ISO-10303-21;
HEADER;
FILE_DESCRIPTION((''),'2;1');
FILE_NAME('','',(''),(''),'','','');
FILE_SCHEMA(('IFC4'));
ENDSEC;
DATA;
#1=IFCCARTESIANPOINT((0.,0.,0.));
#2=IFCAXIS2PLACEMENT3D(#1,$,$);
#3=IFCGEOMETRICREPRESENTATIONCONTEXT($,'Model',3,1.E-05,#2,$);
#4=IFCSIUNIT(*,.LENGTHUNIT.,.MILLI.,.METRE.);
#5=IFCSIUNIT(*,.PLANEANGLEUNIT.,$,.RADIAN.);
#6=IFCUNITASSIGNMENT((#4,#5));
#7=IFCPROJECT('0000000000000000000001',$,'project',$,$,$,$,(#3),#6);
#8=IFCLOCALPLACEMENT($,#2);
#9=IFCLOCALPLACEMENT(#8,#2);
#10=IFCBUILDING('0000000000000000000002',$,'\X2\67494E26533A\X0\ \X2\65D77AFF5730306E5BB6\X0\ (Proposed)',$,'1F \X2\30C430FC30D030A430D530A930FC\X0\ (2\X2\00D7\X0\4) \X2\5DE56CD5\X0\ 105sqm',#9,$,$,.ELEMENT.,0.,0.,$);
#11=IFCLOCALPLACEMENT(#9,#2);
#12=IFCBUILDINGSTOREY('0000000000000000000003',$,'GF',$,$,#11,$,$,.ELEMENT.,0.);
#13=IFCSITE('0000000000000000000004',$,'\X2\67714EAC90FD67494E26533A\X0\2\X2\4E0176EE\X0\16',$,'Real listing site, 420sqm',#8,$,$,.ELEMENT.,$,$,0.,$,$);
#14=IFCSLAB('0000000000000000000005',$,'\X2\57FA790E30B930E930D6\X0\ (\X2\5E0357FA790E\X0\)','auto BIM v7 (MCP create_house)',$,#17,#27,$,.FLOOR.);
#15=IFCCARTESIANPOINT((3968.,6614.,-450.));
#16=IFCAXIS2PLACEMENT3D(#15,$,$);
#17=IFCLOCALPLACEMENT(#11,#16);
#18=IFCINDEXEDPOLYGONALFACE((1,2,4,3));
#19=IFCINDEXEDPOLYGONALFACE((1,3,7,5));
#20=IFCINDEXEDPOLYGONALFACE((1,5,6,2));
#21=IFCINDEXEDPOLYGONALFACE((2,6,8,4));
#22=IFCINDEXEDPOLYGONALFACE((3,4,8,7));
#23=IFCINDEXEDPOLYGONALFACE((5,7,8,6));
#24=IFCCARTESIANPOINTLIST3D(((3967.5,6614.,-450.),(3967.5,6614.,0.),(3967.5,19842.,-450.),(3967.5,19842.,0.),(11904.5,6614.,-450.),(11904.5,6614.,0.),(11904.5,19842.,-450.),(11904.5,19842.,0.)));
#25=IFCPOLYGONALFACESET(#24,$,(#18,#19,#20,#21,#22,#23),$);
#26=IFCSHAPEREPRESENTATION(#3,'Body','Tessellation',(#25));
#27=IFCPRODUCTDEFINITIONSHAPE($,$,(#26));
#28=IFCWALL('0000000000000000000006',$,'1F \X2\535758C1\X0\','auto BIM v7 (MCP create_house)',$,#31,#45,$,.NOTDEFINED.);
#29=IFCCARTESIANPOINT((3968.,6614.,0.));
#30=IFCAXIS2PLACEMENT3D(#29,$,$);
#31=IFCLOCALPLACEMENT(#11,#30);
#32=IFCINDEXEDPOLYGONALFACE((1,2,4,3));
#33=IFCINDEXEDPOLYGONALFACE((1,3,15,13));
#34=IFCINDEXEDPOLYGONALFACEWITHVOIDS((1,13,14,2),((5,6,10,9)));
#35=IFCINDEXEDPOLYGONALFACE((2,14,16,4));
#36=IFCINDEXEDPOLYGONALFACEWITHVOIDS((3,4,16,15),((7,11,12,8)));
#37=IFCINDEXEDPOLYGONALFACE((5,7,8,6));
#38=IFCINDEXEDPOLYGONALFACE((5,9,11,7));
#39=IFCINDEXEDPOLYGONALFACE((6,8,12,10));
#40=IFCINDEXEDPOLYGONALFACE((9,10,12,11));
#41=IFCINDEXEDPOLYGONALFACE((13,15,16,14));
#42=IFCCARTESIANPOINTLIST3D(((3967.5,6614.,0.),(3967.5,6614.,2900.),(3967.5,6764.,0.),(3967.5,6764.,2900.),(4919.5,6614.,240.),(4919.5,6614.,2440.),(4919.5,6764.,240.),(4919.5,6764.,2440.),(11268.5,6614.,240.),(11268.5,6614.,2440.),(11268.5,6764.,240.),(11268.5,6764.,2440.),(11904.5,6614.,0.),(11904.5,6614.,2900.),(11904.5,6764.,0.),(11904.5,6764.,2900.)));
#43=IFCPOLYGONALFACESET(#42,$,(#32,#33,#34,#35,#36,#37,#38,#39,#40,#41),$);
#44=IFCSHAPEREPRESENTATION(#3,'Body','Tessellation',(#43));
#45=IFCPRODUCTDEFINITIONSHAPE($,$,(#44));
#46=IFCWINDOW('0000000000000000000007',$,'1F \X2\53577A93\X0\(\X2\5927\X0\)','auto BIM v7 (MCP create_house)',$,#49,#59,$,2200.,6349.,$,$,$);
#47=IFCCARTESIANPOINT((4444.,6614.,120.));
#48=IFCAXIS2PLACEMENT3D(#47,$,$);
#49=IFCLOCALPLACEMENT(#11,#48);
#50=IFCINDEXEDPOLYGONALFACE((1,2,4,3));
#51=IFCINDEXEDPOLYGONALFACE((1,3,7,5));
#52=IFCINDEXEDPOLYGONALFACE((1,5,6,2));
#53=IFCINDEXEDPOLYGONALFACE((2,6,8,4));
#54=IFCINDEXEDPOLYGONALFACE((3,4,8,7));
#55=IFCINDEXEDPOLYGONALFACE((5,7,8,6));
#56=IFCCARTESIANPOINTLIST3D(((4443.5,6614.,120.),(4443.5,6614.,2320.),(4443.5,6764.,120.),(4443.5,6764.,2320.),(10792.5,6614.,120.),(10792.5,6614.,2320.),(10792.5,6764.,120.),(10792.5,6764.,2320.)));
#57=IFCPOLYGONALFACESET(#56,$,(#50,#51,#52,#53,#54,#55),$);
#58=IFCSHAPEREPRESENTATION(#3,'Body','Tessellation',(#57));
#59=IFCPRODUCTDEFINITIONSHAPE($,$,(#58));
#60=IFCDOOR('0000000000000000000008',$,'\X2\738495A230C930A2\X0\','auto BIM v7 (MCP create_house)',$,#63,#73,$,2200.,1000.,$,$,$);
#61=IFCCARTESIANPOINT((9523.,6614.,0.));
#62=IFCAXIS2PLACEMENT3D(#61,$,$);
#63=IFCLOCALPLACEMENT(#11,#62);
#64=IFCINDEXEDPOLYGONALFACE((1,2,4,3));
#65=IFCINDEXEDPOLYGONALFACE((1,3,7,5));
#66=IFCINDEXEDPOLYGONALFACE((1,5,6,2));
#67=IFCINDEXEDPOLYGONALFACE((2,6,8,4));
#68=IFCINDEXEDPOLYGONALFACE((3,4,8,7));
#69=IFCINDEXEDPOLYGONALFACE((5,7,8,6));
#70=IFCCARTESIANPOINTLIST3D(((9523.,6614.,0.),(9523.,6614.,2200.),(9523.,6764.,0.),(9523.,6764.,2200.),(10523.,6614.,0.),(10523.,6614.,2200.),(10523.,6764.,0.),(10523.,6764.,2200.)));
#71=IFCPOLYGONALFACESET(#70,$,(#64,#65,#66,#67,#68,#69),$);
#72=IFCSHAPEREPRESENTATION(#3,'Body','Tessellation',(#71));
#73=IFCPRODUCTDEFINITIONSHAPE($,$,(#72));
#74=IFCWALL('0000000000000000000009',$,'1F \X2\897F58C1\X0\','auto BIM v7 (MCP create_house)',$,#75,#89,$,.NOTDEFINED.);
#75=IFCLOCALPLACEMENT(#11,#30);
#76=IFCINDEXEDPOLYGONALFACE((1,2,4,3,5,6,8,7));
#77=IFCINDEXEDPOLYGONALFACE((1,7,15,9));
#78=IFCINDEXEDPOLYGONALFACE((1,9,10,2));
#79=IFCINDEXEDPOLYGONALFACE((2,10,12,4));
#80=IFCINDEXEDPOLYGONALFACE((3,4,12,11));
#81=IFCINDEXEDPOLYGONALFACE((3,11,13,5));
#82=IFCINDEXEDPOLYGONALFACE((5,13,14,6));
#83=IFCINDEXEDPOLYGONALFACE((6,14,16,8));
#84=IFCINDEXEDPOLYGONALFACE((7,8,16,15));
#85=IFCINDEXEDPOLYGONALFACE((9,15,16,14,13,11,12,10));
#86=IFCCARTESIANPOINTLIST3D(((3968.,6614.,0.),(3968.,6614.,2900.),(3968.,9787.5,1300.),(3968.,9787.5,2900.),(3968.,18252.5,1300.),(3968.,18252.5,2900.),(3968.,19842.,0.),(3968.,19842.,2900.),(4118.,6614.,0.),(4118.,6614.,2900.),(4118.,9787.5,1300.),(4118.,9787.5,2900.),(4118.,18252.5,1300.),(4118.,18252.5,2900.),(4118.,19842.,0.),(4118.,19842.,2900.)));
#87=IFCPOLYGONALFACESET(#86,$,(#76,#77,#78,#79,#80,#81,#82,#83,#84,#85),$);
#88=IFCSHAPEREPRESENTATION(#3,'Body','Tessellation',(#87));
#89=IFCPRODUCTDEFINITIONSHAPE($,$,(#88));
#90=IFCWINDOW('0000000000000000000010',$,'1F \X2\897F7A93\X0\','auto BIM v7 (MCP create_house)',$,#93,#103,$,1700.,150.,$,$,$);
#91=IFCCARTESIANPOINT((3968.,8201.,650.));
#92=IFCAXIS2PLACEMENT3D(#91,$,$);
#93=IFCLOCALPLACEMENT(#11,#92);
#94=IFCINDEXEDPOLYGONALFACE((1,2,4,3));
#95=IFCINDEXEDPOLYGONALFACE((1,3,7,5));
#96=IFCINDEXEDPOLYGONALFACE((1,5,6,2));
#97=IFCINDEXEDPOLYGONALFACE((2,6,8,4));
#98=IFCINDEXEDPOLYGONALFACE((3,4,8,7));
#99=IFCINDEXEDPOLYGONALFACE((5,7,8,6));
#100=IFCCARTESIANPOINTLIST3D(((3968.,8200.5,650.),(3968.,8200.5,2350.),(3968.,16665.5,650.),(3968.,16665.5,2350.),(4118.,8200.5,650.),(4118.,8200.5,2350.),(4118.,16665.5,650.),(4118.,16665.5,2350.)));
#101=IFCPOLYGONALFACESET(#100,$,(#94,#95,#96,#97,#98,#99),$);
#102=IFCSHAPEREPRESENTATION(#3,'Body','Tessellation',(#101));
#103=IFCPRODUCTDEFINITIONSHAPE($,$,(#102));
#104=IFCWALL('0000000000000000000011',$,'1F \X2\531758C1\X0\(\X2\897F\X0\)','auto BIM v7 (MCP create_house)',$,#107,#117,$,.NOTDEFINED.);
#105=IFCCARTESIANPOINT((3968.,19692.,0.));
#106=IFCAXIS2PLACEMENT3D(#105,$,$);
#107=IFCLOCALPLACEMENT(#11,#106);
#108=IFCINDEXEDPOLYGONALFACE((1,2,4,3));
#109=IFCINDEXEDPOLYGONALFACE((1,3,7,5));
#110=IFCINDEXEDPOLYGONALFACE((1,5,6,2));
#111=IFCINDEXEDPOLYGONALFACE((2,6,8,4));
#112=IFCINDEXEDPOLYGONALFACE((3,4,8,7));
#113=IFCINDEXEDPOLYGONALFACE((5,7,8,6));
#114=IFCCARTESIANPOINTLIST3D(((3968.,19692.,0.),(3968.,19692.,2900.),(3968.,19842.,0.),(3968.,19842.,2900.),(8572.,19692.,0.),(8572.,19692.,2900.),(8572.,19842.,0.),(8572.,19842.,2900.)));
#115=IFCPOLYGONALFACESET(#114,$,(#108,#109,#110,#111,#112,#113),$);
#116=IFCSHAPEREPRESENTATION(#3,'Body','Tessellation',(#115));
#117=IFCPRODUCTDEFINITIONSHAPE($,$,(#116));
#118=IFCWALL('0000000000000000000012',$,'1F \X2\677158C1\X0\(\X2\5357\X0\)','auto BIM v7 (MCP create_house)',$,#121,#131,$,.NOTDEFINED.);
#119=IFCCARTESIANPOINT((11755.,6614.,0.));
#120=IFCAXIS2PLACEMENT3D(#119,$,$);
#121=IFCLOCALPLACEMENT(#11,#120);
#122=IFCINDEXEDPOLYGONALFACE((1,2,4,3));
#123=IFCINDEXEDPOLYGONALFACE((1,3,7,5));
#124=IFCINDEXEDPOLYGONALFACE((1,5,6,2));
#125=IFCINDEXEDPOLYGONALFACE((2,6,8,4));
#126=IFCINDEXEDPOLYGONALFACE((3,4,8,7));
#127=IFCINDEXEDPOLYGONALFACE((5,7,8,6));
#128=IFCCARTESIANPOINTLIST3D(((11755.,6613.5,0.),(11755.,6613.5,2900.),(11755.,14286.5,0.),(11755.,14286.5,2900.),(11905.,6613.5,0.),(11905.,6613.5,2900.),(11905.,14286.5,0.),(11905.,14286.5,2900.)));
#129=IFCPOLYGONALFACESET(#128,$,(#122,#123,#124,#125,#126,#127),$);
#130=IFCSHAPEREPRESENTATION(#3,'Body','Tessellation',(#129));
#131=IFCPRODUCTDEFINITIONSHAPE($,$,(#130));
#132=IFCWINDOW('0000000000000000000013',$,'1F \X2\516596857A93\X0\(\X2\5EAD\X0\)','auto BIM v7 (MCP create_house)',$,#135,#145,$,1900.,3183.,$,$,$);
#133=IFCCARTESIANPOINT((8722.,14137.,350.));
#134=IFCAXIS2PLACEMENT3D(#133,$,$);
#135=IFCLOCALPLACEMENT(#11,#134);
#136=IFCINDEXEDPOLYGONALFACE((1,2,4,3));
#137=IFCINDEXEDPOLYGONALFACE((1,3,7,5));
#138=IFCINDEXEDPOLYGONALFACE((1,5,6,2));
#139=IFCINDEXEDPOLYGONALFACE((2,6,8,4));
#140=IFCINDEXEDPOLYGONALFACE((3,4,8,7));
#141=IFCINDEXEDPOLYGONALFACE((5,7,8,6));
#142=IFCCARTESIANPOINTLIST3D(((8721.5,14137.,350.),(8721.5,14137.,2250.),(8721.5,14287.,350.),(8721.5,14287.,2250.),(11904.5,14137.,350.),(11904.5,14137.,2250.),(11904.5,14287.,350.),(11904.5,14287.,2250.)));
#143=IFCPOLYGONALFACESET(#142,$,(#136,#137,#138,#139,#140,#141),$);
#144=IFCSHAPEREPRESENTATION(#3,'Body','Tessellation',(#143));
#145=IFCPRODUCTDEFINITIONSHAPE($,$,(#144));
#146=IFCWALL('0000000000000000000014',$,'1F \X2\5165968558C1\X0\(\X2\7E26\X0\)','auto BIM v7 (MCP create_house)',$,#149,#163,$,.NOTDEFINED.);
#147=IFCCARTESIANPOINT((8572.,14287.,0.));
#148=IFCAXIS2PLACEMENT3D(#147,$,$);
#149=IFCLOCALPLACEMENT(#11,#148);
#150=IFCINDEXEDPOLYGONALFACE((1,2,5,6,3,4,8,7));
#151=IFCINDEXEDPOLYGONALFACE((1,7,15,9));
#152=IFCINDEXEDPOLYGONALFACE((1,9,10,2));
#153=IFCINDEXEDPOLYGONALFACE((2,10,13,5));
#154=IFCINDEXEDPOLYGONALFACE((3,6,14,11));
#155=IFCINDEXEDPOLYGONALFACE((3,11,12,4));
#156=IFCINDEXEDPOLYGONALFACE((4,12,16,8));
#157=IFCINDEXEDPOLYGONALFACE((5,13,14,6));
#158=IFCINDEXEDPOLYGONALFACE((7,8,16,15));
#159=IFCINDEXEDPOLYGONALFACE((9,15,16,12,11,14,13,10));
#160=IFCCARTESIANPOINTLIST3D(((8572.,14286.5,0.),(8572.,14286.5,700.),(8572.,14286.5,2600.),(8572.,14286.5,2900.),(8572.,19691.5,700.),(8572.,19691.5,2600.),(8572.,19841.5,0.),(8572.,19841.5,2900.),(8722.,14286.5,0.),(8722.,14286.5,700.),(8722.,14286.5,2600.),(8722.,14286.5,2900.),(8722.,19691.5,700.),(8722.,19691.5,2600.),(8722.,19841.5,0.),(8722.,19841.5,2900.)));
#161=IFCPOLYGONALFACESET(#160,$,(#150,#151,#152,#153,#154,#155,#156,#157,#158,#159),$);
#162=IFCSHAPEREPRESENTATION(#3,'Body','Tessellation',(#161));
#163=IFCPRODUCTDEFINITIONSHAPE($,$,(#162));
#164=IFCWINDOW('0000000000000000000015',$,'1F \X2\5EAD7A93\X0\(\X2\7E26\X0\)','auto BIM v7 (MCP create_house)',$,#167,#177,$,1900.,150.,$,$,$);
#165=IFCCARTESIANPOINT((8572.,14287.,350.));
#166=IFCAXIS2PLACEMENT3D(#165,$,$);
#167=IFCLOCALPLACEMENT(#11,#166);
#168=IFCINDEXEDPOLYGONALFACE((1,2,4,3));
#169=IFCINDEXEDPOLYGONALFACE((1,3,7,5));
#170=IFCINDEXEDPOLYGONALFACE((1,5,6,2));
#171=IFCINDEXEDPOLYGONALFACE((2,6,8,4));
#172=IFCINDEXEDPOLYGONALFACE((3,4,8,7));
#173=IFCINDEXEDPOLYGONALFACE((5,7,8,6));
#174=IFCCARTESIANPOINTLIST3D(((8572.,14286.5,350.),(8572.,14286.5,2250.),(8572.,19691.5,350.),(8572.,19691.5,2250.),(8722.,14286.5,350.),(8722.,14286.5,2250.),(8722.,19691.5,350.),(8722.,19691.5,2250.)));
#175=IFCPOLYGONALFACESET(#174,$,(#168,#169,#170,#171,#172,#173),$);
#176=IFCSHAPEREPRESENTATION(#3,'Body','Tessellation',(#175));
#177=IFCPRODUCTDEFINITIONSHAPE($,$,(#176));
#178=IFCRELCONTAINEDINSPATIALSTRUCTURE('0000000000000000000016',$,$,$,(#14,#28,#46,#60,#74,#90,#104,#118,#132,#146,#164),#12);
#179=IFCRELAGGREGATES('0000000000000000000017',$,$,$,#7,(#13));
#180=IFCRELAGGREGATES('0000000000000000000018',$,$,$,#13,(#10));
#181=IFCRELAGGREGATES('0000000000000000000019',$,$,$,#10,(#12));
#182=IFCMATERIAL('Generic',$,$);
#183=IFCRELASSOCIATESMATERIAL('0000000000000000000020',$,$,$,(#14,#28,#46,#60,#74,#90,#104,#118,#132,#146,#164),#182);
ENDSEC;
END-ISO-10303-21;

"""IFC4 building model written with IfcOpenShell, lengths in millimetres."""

from ifc_helpers import new_model, si_unit, frame, frame_2d, origin, place, context, project, spatial, rectangle, extrude, material, element, fill, save


model = new_model("IFC4")

# Units and contexts
model_context = context("Model", 3, precision=1e-05, world=origin())
ifc_project = project(units=[si_unit("LENGTHUNIT", "METRE", prefix="MILLI"), si_unit("PLANEANGLEUNIT", "RADIAN")], contexts=[model_context])

# Site, building, storey
site_placement = place(None, origin())
site = spatial("IfcSite", under=ifc_project, at=site_placement, Name="東京都杉並区2丁目16", ObjectType="Real listing site, 420sqm", CompositionType="ELEMENT", RefElevation=0.0)
building_placement = place(site_placement, origin())
building = spatial("IfcBuilding", under=site, at=building_placement, Name="杉並区 旗竿地の家 (Proposed)", ObjectType="1F ツーバイフォー (2×4) 工法 105sqm", CompositionType="ELEMENT", ElevationOfRefHeight=0.0, ElevationOfTerrain=0.0)
storey_placement = place(building_placement, origin())
storey = spatial("IfcBuildingStorey", under=building, at=storey_placement, Name="GF", CompositionType="ELEMENT", Elevation=0.0)

# Slab
ifc_material = material(Name="Generic")
slab_1_placement = place(storey_placement, frame((3968.0, 6614.0, -450.0)))
element("IfcSlab", 1, at=slab_1_placement, inside=storey, material=ifc_material, Name="基礎スラブ (布基礎)", Description="auto BIM v7 (MCP create_house)", PredefinedType="FLOOR", context=model_context, shape_type="SweptSolid", body=[
    extrude(rectangle(XDim=7937.0, YDim=13228.0, at=frame_2d((3968.0, 6614.0))), frame((3968.0, 6614.0, -450.0)), (0.0, 0.0, 1.0), 450.0),
])

# Wall, openings, window, door
wall_1_placement = place(storey_placement, frame((3968.0, 6614.0, 0.0)))
wall_1 = element("IfcWall", 2, at=wall_1_placement, inside=storey, material=ifc_material, Name="1F 南壁", Description="auto BIM v7 (MCP create_house)", PredefinedType="NOTDEFINED", context=model_context, shape_type="SweptSolid", body=[
    extrude(rectangle(XDim=7937.0, YDim=150.0, at=frame_2d((3968.0, 75.0))), frame((3968.0, 6614.0, 0.0)), (0.0, 0.0, 1.0), 2900.0),
])
opening_1_placement = place(storey_placement, frame((4444.0, 6614.0, 120.0)))
opening_1 = element("IfcOpeningElement", 3, at=opening_1_placement, cuts=wall_1, PredefinedType="NOTDEFINED", context=model_context, shape_type="SweptSolid", body=[
    extrude(rectangle(XDim=6349.0, YDim=150.0, at=frame_2d((3174.0, 75.0))), frame((4444.0, 6614.0, 120.0)), (0.0, 0.0, 1.0), 2200.0),
])
opening_2_placement = place(storey_placement, frame((9523.0, 6614.0, 0.0)))
opening_2 = element("IfcOpeningElement", 4, at=opening_2_placement, cuts=wall_1, PredefinedType="NOTDEFINED", context=model_context, shape_type="SweptSolid", body=[
    extrude(rectangle(XDim=1000.0, YDim=150.0, at=frame_2d((500.0, 75.0))), frame((9523.0, 6614.0, 0.0)), (0.0, 0.0, 1.0), 2200.0),
])
window_1_placement = place(storey_placement, frame((4444.0, 6614.0, 120.0)))
window_1 = element("IfcWindow", 5, at=window_1_placement, inside=storey, material=ifc_material, Name="1F 南窓(大)", Description="auto BIM v7 (MCP create_house)", OverallHeight=2200.0, OverallWidth=6349.0, context=model_context, shape_type="SweptSolid", body=[
    extrude(rectangle(XDim=6349.0, YDim=150.0, at=frame_2d((3174.0, 75.0))), frame((4444.0, 6614.0, 120.0)), (0.0, 0.0, 1.0), 2200.0),
])
fill(opening_1, window_1)
door_placement = place(storey_placement, frame((9523.0, 6614.0, 0.0)))
door = element("IfcDoor", 6, at=door_placement, inside=storey, material=ifc_material, Name="玄関ドア", Description="auto BIM v7 (MCP create_house)", OverallHeight=2200.0, OverallWidth=1000.0, context=model_context, shape_type="SweptSolid", body=[
    extrude(rectangle(XDim=1000.0, YDim=150.0, at=frame_2d((500.0, 75.0))), frame((9523.0, 6614.0, 0.0)), (0.0, 0.0, 1.0), 2200.0),
])
fill(opening_2, door)

# Wall, opening, window
wall_2_placement = place(storey_placement, frame((3968.0, 6614.0, 0.0)))
wall_2 = element("IfcWall", 7, at=wall_2_placement, inside=storey, material=ifc_material, Name="1F 西壁", Description="auto BIM v7 (MCP create_house)", PredefinedType="NOTDEFINED", context=model_context, shape_type="SweptSolid", body=[
    extrude(rectangle(XDim=150.0, YDim=13228.0, at=frame_2d((75.0, 6614.0))), frame((3968.0, 6614.0, 0.0)), (0.0, 0.0, 1.0), 2900.0),
])
opening_3_placement = place(storey_placement, frame((3968.0, 8201.0, 650.0)))
opening_3 = element("IfcOpeningElement", 8, at=opening_3_placement, cuts=wall_2, PredefinedType="NOTDEFINED", context=model_context, shape_type="SweptSolid", body=[
    extrude(rectangle(XDim=150.0, YDim=8465.0, at=frame_2d((75.0, 4232.0))), frame((3968.0, 8201.0, 650.0)), (0.0, 0.0, 1.0), 1700.0),
])
window_2_placement = place(storey_placement, frame((3968.0, 8201.0, 650.0)))
window_2 = element("IfcWindow", 9, at=window_2_placement, inside=storey, material=ifc_material, Name="1F 西窓", Description="auto BIM v7 (MCP create_house)", OverallHeight=1700.0, OverallWidth=150.0, context=model_context, shape_type="SweptSolid", body=[
    extrude(rectangle(XDim=150.0, YDim=8465.0, at=frame_2d((75.0, 4232.0))), frame((3968.0, 8201.0, 650.0)), (0.0, 0.0, 1.0), 1700.0),
])
fill(opening_3, window_2)

# Wall
wall_3_placement = place(storey_placement, frame((3968.0, 19692.0, 0.0)))
element("IfcWall", 10, at=wall_3_placement, inside=storey, material=ifc_material, Name="1F 北壁(西)", Description="auto BIM v7 (MCP create_house)", PredefinedType="NOTDEFINED", context=model_context, shape_type="SweptSolid", body=[
    extrude(rectangle(XDim=4604.0, YDim=150.0, at=frame_2d((2302.0, 75.0))), frame((3968.0, 19692.0, 0.0)), (0.0, 0.0, 1.0), 2900.0),
])

# Wall, opening, window
wall_4_placement = place(storey_placement, frame((11755.0, 6614.0, 0.0)))
wall_4 = element("IfcWall", 11, at=wall_4_placement, inside=storey, material=ifc_material, Name="1F 東壁(南)", Description="auto BIM v7 (MCP create_house)", PredefinedType="NOTDEFINED", context=model_context, shape_type="SweptSolid", body=[
    extrude(rectangle(XDim=150.0, YDim=7673.0, at=frame_2d((75.0, 3836.0))), frame((11755.0, 6614.0, 0.0)), (0.0, 0.0, 1.0), 2900.0),
])
opening_4_placement = place(storey_placement, frame((8722.0, 14137.0, 350.0)))
opening_4 = element("IfcOpeningElement", 12, at=opening_4_placement, cuts=wall_4, PredefinedType="NOTDEFINED", context=model_context, shape_type="SweptSolid", body=[
    extrude(rectangle(XDim=3183.0, YDim=150.0, at=frame_2d((1591.0, 75.0))), frame((8722.0, 14137.0, 350.0)), (0.0, 0.0, 1.0), 1900.0),
])
window_3_placement = place(storey_placement, frame((8722.0, 14137.0, 350.0)))
window_3 = element("IfcWindow", 13, at=window_3_placement, inside=storey, material=ifc_material, Name="1F 入隅窓(庭)", Description="auto BIM v7 (MCP create_house)", OverallHeight=1900.0, OverallWidth=3183.0, context=model_context, shape_type="SweptSolid", body=[
    extrude(rectangle(XDim=3183.0, YDim=150.0, at=frame_2d((1591.0, 75.0))), frame((8722.0, 14137.0, 350.0)), (0.0, 0.0, 1.0), 1900.0),
])
fill(opening_4, window_3)

# Wall, opening, window
wall_5_placement = place(storey_placement, frame((8572.0, 14287.0, 0.0)))
wall_5 = element("IfcWall", 14, at=wall_5_placement, inside=storey, material=ifc_material, Name="1F 入隅壁(縦)", Description="auto BIM v7 (MCP create_house)", PredefinedType="NOTDEFINED", context=model_context, shape_type="SweptSolid", body=[
    extrude(rectangle(XDim=150.0, YDim=5555.0, at=frame_2d((75.0, 2777.0))), frame((8572.0, 14287.0, 0.0)), (0.0, 0.0, 1.0), 2900.0),
])
opening_5_placement = place(storey_placement, frame((8572.0, 14287.0, 350.0)))
opening_5 = element("IfcOpeningElement", 15, at=opening_5_placement, cuts=wall_5, PredefinedType="NOTDEFINED", context=model_context, shape_type="SweptSolid", body=[
    extrude(rectangle(XDim=150.0, YDim=5405.0, at=frame_2d((75.0, 2702.0))), frame((8572.0, 14287.0, 350.0)), (0.0, 0.0, 1.0), 1900.0),
])
window_4_placement = place(storey_placement, frame((8572.0, 14287.0, 350.0)))
window_4 = element("IfcWindow", 16, at=window_4_placement, inside=storey, material=ifc_material, Name="1F 庭窓(縦)", Description="auto BIM v7 (MCP create_house)", OverallHeight=1900.0, OverallWidth=150.0, context=model_context, shape_type="SweptSolid", body=[
    extrude(rectangle(XDim=150.0, YDim=5405.0, at=frame_2d((75.0, 2702.0))), frame((8572.0, 14287.0, 350.0)), (0.0, 0.0, 1.0), 1900.0),
])
fill(opening_5, window_4)

save(model, "model.ifc")
